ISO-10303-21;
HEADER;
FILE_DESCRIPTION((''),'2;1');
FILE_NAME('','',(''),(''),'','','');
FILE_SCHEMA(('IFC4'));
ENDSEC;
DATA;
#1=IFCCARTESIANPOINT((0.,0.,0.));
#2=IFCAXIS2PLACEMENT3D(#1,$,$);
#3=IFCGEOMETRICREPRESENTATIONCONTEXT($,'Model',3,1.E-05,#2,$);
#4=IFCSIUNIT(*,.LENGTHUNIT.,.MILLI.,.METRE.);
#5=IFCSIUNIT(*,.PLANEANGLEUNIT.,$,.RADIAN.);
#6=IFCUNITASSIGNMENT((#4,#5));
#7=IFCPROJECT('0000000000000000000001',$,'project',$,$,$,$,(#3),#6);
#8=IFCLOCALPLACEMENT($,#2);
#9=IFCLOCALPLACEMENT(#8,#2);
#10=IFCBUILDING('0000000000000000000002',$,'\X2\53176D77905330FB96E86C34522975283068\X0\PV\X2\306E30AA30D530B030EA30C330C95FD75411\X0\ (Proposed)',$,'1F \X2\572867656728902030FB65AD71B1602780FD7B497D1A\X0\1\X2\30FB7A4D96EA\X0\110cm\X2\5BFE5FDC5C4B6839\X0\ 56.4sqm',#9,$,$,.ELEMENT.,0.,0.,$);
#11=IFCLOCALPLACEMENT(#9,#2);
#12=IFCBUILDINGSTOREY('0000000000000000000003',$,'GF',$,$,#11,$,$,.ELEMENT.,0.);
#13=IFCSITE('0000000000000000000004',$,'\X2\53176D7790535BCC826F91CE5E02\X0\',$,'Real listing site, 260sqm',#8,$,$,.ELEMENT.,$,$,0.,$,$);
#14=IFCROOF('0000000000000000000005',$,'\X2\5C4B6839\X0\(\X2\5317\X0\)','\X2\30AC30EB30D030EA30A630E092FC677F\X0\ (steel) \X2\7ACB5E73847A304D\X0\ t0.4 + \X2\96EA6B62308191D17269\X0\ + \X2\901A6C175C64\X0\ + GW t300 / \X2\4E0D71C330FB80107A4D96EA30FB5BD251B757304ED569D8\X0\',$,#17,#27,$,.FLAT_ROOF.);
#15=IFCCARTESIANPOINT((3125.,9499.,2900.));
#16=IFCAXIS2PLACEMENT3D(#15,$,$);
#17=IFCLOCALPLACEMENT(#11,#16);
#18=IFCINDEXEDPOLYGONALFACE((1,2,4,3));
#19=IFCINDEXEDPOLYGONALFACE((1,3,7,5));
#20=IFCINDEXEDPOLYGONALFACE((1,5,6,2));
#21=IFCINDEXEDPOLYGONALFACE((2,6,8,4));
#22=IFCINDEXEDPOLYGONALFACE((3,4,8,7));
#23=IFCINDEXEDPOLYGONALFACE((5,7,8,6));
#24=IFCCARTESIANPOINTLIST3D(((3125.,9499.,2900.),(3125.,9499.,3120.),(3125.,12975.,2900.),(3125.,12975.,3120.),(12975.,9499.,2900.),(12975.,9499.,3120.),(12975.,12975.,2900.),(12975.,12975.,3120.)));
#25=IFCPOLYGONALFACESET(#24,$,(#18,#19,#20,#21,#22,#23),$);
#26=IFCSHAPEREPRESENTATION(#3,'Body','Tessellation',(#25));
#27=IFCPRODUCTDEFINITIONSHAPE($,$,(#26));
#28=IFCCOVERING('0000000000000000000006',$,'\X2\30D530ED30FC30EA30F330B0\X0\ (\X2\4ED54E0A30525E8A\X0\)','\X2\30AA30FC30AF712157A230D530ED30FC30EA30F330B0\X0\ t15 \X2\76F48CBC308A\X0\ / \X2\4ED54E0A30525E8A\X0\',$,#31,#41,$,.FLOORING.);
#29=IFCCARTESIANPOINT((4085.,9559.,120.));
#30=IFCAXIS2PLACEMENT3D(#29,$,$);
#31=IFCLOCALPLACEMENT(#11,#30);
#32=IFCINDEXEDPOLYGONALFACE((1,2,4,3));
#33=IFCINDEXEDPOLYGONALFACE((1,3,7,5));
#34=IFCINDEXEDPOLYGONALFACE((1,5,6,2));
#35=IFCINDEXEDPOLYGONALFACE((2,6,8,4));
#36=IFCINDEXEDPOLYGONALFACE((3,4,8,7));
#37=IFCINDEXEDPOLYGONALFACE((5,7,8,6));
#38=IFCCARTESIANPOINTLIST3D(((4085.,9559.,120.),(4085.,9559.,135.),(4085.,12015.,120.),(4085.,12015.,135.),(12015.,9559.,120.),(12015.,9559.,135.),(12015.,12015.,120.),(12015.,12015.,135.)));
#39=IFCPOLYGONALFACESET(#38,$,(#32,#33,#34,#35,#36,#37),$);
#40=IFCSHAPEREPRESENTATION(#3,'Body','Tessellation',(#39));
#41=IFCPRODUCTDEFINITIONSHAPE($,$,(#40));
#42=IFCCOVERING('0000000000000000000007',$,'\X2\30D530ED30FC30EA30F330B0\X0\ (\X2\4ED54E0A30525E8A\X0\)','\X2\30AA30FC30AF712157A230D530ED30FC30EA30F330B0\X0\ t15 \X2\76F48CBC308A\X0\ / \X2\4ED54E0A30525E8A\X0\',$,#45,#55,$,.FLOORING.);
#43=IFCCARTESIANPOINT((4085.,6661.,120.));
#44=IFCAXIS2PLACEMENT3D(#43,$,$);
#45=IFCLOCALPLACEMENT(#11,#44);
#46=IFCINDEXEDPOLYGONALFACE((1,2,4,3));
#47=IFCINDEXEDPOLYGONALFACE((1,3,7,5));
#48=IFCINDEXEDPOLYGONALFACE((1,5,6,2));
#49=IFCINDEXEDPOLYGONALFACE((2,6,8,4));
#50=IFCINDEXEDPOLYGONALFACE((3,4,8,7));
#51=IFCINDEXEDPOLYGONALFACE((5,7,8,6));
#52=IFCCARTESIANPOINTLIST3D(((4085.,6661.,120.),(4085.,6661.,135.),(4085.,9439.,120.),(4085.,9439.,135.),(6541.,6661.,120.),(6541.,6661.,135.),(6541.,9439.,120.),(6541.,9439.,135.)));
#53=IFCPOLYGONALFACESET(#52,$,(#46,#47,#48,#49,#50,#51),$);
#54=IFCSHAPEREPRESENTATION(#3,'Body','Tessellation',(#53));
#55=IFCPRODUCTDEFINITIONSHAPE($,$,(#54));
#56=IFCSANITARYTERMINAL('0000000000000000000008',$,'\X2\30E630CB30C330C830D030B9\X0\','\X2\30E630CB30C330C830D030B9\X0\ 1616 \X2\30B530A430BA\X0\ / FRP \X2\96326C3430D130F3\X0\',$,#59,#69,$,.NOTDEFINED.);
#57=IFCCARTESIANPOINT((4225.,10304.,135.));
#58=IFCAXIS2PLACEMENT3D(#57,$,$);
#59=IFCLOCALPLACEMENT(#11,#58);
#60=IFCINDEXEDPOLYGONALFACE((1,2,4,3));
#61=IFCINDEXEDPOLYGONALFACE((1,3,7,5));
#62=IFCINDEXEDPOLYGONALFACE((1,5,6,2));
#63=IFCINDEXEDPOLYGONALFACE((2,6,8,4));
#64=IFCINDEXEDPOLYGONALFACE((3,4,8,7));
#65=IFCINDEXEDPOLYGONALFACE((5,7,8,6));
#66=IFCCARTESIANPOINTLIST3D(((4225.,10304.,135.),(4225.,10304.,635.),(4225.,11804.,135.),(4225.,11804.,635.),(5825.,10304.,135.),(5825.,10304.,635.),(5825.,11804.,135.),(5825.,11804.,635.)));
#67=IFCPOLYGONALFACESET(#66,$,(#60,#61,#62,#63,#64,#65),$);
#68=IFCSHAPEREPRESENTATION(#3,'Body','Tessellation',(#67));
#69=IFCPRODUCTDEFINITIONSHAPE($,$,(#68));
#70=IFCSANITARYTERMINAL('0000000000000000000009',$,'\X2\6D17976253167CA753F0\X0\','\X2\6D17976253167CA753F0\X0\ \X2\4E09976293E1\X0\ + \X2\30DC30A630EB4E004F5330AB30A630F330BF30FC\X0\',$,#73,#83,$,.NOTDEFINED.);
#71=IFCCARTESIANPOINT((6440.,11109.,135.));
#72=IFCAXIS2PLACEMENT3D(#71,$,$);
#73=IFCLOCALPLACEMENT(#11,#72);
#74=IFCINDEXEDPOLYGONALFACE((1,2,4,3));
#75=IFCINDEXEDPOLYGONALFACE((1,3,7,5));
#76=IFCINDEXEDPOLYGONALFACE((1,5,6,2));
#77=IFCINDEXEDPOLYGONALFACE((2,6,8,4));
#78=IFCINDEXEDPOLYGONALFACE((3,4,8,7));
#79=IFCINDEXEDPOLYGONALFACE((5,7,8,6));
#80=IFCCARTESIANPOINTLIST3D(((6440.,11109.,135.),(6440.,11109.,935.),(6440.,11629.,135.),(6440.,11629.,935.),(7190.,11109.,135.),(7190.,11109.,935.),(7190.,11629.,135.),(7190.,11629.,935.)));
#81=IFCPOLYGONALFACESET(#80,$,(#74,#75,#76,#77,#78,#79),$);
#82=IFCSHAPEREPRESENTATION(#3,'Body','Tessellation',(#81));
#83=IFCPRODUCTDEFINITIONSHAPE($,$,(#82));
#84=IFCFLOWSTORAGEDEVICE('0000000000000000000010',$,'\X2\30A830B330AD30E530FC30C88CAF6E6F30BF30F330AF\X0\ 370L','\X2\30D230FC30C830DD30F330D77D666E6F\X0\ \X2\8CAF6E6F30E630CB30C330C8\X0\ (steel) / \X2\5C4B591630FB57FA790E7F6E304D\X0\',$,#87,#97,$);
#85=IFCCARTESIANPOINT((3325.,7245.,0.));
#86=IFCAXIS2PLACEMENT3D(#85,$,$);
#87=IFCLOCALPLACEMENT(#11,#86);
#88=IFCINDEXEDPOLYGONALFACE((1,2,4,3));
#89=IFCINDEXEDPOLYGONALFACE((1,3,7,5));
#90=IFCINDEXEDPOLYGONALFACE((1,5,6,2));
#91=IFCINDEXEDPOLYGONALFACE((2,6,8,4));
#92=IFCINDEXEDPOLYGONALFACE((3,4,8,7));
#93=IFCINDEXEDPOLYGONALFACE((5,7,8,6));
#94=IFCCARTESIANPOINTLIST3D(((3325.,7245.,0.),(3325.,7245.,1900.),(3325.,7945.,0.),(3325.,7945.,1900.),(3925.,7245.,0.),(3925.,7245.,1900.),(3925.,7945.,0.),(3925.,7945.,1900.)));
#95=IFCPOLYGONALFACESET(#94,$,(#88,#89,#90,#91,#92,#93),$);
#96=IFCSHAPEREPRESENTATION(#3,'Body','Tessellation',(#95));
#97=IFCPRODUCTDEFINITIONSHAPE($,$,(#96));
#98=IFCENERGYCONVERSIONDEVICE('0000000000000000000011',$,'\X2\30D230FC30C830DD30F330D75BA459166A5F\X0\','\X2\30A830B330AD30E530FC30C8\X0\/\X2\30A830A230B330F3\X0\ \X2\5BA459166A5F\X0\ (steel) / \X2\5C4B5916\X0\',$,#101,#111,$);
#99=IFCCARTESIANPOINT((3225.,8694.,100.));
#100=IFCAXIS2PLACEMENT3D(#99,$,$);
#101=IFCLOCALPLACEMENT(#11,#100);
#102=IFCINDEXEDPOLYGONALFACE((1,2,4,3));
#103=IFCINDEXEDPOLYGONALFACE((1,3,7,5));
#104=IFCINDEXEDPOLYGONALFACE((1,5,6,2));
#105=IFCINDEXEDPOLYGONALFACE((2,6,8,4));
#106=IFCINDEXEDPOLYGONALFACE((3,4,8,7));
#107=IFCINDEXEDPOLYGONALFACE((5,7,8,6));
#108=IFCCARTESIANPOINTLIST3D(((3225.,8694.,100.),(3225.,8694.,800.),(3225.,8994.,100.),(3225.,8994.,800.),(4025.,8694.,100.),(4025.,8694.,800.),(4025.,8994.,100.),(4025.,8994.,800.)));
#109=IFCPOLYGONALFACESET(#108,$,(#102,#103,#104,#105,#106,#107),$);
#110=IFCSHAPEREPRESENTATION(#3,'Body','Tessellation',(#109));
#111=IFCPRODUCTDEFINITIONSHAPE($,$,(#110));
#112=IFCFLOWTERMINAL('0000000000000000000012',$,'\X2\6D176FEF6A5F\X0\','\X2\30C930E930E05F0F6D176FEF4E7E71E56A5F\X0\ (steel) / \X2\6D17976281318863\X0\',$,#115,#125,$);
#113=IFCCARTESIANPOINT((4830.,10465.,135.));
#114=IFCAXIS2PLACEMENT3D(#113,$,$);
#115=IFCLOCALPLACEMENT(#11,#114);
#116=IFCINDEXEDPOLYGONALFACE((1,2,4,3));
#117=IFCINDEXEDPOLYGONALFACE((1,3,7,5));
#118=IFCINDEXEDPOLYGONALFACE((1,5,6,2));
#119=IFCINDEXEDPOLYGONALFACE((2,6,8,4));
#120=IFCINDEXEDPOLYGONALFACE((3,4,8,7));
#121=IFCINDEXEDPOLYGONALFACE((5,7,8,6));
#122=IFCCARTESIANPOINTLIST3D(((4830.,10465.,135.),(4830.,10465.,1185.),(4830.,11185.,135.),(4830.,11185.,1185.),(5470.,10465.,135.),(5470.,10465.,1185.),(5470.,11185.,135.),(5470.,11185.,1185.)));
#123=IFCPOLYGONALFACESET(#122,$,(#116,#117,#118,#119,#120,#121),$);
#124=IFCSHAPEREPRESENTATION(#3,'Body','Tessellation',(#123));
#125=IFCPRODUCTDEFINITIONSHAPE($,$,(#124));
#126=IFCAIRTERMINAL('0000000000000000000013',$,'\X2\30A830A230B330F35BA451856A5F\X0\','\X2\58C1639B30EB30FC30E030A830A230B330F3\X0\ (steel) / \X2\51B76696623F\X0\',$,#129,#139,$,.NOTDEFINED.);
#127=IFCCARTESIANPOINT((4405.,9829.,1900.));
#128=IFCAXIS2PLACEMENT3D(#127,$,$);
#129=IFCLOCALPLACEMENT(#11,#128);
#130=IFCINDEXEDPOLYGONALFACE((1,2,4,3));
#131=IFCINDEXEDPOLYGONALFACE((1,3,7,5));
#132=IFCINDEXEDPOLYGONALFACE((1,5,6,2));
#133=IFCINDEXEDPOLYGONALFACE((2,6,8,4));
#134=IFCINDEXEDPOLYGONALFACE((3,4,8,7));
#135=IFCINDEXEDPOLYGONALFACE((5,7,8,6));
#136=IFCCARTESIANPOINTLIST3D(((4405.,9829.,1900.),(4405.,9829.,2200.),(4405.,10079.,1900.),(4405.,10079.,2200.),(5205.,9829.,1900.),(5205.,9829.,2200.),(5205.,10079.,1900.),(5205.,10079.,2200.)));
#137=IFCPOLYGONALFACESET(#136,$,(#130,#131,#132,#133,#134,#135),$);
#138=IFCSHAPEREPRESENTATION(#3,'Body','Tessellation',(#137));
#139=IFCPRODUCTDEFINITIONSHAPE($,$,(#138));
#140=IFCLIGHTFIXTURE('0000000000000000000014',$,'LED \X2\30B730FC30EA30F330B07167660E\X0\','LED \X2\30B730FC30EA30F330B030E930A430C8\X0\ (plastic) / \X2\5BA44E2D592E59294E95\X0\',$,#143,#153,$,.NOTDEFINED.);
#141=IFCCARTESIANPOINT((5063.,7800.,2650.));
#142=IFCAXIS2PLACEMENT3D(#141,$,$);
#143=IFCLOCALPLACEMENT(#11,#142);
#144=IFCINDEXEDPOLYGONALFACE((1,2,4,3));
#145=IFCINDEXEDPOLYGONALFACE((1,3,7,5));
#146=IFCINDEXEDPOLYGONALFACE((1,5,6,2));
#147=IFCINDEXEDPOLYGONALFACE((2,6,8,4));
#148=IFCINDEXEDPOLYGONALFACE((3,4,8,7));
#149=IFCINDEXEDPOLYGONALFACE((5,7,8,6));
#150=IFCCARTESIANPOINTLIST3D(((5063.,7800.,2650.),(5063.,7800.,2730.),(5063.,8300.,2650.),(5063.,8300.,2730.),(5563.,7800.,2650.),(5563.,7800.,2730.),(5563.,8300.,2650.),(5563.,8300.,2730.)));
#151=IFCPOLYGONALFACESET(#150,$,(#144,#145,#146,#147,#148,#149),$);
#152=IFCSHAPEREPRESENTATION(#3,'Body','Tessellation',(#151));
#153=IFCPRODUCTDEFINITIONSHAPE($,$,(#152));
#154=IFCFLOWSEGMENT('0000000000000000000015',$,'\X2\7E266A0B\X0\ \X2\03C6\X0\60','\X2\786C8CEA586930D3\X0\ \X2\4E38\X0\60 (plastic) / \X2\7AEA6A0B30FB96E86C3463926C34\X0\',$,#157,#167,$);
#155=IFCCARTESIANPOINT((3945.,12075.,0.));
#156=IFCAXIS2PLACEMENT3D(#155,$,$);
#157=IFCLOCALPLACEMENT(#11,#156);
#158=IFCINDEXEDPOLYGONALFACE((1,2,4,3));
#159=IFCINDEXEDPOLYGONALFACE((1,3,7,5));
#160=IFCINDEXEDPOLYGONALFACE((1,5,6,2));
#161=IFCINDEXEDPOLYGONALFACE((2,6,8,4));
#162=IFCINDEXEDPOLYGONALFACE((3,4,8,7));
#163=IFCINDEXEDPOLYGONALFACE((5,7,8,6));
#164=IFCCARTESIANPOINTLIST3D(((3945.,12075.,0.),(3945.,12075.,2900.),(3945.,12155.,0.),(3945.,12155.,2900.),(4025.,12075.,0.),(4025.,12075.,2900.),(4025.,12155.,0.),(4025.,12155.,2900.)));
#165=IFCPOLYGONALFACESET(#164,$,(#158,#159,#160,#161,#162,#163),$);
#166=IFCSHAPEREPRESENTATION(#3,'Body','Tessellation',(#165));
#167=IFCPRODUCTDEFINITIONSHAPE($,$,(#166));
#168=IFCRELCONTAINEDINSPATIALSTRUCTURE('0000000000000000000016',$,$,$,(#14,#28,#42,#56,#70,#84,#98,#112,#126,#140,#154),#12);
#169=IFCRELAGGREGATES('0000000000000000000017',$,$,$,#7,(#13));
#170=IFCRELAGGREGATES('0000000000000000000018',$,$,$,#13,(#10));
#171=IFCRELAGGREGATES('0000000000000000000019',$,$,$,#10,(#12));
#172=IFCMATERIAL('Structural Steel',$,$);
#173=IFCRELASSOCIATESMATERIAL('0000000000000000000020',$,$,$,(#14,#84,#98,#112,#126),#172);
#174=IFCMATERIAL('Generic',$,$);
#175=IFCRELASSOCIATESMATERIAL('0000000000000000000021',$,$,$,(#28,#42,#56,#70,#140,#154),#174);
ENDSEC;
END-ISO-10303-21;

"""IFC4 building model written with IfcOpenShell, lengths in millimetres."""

from ifc_helpers import new_model, si_unit, frame, frame_2d, origin, place, context, project, spatial, rectangle, extrude, material, element, save


model = new_model("IFC4")

# Units and contexts
model_context = context("Model", 3, precision=1e-05, world=origin())
ifc_project = project(units=[si_unit("LENGTHUNIT", "METRE", prefix="MILLI"), si_unit("PLANEANGLEUNIT", "RADIAN")], contexts=[model_context])

# Site, building, storey
site_placement = place(None, origin())
site = spatial("IfcSite", under=ifc_project, at=site_placement, Name="北海道富良野市", ObjectType="Real listing site, 260sqm", CompositionType="ELEMENT", RefElevation=0.0)
building_placement = place(site_placement, origin())
building = spatial("IfcBuilding", under=site, at=building_placement, Name="北海道・雨水利用とPVのオフグリッド志向 (Proposed)", ObjectType="1F 在来木造・断熱性能等級1・積雪110cm対応屋根 56.4sqm", CompositionType="ELEMENT", ElevationOfRefHeight=0.0, ElevationOfTerrain=0.0)
storey_placement = place(building_placement, origin())
storey = spatial("IfcBuildingStorey", under=building, at=storey_placement, Name="GF", CompositionType="ELEMENT", Elevation=0.0)

# Roof
ifc_material_1 = material(Name="Structural Steel")
roof_placement = place(storey_placement, frame((3125.0, 9499.0, 2900.0)))
element("IfcRoof", 1, at=roof_placement, inside=storey, material=ifc_material_1, Name="屋根(北)", Description="ガルバリウム鋼板 (steel) 立平葺き t0.4 + 雪止め金物 + 通気層 + GW t300 / 不燃・耐積雪・寒冷地仕様", PredefinedType="FLAT_ROOF", context=model_context, shape_type="SweptSolid", body=[
    extrude(rectangle(XDim=9850.0, YDim=3476.0, at=frame_2d((4925.0, 1738.0))), frame((3125.0, 9499.0, 2900.0)), (0.0, 0.0, 1.0), 220.0),
])

# Coverings
ifc_material_2 = material(Name="Generic")
covering_1_placement = place(storey_placement, frame((4085.0, 9559.0, 120.0)))
element("IfcCovering", 2, at=covering_1_placement, inside=storey, material=ifc_material_2, Name="フローリング (仕上げ床)", Description="オーク無垢フローリング t15 直貼り / 仕上げ床", PredefinedType="FLOORING", context=model_context, shape_type="SweptSolid", body=[
    extrude(rectangle(XDim=7930.0, YDim=2456.0, at=frame_2d((3965.0, 1228.0))), frame((4085.0, 9559.0, 120.0)), (0.0, 0.0, 1.0), 15.0),
])
covering_2_placement = place(storey_placement, frame((4085.0, 6661.0, 120.0)))
element("IfcCovering", 3, at=covering_2_placement, inside=storey, material=ifc_material_2, Name="フローリング (仕上げ床)", Description="オーク無垢フローリング t15 直貼り / 仕上げ床", PredefinedType="FLOORING", context=model_context, shape_type="SweptSolid", body=[
    extrude(rectangle(XDim=2456.0, YDim=2778.0, at=frame_2d((1228.0, 1389.0))), frame((4085.0, 6661.0, 120.0)), (0.0, 0.0, 1.0), 15.0),
])

# Sanitary terminals
sanitary_terminal_1_placement = place(storey_placement, frame((4225.0, 10304.0, 135.0)))
element("IfcSanitaryTerminal", 4, at=sanitary_terminal_1_placement, inside=storey, material=ifc_material_2, Name="ユニットバス", Description="ユニットバス 1616 サイズ / FRP 防水パン", PredefinedType="NOTDEFINED", context=model_context, shape_type="SweptSolid", body=[
    extrude(rectangle(XDim=1600.0, YDim=1500.0, at=frame_2d((800.0, 750.0))), frame((4225.0, 10304.0, 135.0)), (0.0, 0.0, 1.0), 500.0),
])
sanitary_terminal_2_placement = place(storey_placement, frame((6440.0, 11109.0, 135.0)))
element("IfcSanitaryTerminal", 5, at=sanitary_terminal_2_placement, inside=storey, material=ifc_material_2, Name="洗面化粧台", Description="洗面化粧台 三面鏡 + ボウル一体カウンター", PredefinedType="NOTDEFINED", context=model_context, shape_type="SweptSolid", body=[
    extrude(rectangle(XDim=750.0, YDim=520.0, at=frame_2d((375.0, 260.0))), frame((6440.0, 11109.0, 135.0)), (0.0, 0.0, 1.0), 800.0),
])

# Flow storage device
flow_storage_device_placement = place(storey_placement, frame((3325.0, 7245.0, 0.0)))
element("IfcFlowStorageDevice", 6, at=flow_storage_device_placement, inside=storey, material=ifc_material_1, Name="エコキュート貯湯タンク 370L", Description="ヒートポンプ給湯 貯湯ユニット (steel) / 屋外・基礎置き", context=model_context, shape_type="SweptSolid", body=[
    extrude(rectangle(XDim=600.0, YDim=700.0, at=frame_2d((300.0, 350.0))), frame((3325.0, 7245.0, 0.0)), (0.0, 0.0, 1.0), 1900.0),
])

# Energy conversion device
energy_conversion_device_placement = place(storey_placement, frame((3225.0, 8694.0, 100.0)))
element("IfcEnergyConversionDevice", 7, at=energy_conversion_device_placement, inside=storey, material=ifc_material_1, Name="ヒートポンプ室外機", Description="エコキュート/エアコン 室外機 (steel) / 屋外", context=model_context, shape_type="SweptSolid", body=[
    extrude(rectangle(XDim=800.0, YDim=300.0, at=frame_2d((400.0, 150.0))), frame((3225.0, 8694.0, 100.0)), (0.0, 0.0, 1.0), 700.0),
])

# Flow terminal
flow_terminal_placement = place(storey_placement, frame((4830.0, 10465.0, 135.0)))
element("IfcFlowTerminal", 8, at=flow_terminal_placement, inside=storey, material=ifc_material_1, Name="洗濯機", Description="ドラム式洗濯乾燥機 (steel) / 洗面脱衣", context=model_context, shape_type="SweptSolid", body=[
    extrude(rectangle(XDim=640.0, YDim=720.0, at=frame_2d((320.0, 360.0))), frame((4830.0, 10465.0, 135.0)), (0.0, 0.0, 1.0), 1050.0),
])

# Air terminal
air_terminal_placement = place(storey_placement, frame((4405.0, 9829.0, 1900.0)))
element("IfcAirTerminal", 9, at=air_terminal_placement, inside=storey, material=ifc_material_1, Name="エアコン室内機", Description="壁掛ルームエアコン (steel) / 冷暖房", PredefinedType="NOTDEFINED", context=model_context, shape_type="SweptSolid", body=[
    extrude(rectangle(XDim=800.0, YDim=250.0, at=frame_2d((400.0, 125.0))), frame((4405.0, 9829.0, 1900.0)), (0.0, 0.0, 1.0), 300.0),
])

# Light fixture
light_fixture_placement = place(storey_placement, frame((5063.0, 7800.0, 2650.0)))
element("IfcLightFixture", 10, at=light_fixture_placement, inside=storey, material=ifc_material_2, Name="LED シーリング照明", Description="LED シーリングライト (plastic) / 室中央天井", PredefinedType="NOTDEFINED", context=model_context, shape_type="SweptSolid", body=[
    extrude(rectangle(XDim=500.0, YDim=500.0, at=frame_2d((250.0, 250.0))), frame((5063.0, 7800.0, 2650.0)), (0.0, 0.0, 1.0), 80.0),
])

# Flow segment
flow_segment_1_placement = place(storey_placement, frame((3945.0, 12075.0, 0.0)))
element("IfcFlowSegment", 11, at=flow_segment_1_placement, inside=storey, material=ifc_material_2, Name="縦樋 φ60", Description="硬質塩ビ 丸60 (plastic) / 竪樋・雨水排水", context=model_context, shape_type="SweptSolid", body=[
    extrude(rectangle(XDim=80.0, YDim=80.0, at=frame_2d((40.0, 40.0))), frame((3945.0, 12075.0, 0.0)), (0.0, 0.0, 1.0), 2900.0),
])

save(model, "model.ifc")
